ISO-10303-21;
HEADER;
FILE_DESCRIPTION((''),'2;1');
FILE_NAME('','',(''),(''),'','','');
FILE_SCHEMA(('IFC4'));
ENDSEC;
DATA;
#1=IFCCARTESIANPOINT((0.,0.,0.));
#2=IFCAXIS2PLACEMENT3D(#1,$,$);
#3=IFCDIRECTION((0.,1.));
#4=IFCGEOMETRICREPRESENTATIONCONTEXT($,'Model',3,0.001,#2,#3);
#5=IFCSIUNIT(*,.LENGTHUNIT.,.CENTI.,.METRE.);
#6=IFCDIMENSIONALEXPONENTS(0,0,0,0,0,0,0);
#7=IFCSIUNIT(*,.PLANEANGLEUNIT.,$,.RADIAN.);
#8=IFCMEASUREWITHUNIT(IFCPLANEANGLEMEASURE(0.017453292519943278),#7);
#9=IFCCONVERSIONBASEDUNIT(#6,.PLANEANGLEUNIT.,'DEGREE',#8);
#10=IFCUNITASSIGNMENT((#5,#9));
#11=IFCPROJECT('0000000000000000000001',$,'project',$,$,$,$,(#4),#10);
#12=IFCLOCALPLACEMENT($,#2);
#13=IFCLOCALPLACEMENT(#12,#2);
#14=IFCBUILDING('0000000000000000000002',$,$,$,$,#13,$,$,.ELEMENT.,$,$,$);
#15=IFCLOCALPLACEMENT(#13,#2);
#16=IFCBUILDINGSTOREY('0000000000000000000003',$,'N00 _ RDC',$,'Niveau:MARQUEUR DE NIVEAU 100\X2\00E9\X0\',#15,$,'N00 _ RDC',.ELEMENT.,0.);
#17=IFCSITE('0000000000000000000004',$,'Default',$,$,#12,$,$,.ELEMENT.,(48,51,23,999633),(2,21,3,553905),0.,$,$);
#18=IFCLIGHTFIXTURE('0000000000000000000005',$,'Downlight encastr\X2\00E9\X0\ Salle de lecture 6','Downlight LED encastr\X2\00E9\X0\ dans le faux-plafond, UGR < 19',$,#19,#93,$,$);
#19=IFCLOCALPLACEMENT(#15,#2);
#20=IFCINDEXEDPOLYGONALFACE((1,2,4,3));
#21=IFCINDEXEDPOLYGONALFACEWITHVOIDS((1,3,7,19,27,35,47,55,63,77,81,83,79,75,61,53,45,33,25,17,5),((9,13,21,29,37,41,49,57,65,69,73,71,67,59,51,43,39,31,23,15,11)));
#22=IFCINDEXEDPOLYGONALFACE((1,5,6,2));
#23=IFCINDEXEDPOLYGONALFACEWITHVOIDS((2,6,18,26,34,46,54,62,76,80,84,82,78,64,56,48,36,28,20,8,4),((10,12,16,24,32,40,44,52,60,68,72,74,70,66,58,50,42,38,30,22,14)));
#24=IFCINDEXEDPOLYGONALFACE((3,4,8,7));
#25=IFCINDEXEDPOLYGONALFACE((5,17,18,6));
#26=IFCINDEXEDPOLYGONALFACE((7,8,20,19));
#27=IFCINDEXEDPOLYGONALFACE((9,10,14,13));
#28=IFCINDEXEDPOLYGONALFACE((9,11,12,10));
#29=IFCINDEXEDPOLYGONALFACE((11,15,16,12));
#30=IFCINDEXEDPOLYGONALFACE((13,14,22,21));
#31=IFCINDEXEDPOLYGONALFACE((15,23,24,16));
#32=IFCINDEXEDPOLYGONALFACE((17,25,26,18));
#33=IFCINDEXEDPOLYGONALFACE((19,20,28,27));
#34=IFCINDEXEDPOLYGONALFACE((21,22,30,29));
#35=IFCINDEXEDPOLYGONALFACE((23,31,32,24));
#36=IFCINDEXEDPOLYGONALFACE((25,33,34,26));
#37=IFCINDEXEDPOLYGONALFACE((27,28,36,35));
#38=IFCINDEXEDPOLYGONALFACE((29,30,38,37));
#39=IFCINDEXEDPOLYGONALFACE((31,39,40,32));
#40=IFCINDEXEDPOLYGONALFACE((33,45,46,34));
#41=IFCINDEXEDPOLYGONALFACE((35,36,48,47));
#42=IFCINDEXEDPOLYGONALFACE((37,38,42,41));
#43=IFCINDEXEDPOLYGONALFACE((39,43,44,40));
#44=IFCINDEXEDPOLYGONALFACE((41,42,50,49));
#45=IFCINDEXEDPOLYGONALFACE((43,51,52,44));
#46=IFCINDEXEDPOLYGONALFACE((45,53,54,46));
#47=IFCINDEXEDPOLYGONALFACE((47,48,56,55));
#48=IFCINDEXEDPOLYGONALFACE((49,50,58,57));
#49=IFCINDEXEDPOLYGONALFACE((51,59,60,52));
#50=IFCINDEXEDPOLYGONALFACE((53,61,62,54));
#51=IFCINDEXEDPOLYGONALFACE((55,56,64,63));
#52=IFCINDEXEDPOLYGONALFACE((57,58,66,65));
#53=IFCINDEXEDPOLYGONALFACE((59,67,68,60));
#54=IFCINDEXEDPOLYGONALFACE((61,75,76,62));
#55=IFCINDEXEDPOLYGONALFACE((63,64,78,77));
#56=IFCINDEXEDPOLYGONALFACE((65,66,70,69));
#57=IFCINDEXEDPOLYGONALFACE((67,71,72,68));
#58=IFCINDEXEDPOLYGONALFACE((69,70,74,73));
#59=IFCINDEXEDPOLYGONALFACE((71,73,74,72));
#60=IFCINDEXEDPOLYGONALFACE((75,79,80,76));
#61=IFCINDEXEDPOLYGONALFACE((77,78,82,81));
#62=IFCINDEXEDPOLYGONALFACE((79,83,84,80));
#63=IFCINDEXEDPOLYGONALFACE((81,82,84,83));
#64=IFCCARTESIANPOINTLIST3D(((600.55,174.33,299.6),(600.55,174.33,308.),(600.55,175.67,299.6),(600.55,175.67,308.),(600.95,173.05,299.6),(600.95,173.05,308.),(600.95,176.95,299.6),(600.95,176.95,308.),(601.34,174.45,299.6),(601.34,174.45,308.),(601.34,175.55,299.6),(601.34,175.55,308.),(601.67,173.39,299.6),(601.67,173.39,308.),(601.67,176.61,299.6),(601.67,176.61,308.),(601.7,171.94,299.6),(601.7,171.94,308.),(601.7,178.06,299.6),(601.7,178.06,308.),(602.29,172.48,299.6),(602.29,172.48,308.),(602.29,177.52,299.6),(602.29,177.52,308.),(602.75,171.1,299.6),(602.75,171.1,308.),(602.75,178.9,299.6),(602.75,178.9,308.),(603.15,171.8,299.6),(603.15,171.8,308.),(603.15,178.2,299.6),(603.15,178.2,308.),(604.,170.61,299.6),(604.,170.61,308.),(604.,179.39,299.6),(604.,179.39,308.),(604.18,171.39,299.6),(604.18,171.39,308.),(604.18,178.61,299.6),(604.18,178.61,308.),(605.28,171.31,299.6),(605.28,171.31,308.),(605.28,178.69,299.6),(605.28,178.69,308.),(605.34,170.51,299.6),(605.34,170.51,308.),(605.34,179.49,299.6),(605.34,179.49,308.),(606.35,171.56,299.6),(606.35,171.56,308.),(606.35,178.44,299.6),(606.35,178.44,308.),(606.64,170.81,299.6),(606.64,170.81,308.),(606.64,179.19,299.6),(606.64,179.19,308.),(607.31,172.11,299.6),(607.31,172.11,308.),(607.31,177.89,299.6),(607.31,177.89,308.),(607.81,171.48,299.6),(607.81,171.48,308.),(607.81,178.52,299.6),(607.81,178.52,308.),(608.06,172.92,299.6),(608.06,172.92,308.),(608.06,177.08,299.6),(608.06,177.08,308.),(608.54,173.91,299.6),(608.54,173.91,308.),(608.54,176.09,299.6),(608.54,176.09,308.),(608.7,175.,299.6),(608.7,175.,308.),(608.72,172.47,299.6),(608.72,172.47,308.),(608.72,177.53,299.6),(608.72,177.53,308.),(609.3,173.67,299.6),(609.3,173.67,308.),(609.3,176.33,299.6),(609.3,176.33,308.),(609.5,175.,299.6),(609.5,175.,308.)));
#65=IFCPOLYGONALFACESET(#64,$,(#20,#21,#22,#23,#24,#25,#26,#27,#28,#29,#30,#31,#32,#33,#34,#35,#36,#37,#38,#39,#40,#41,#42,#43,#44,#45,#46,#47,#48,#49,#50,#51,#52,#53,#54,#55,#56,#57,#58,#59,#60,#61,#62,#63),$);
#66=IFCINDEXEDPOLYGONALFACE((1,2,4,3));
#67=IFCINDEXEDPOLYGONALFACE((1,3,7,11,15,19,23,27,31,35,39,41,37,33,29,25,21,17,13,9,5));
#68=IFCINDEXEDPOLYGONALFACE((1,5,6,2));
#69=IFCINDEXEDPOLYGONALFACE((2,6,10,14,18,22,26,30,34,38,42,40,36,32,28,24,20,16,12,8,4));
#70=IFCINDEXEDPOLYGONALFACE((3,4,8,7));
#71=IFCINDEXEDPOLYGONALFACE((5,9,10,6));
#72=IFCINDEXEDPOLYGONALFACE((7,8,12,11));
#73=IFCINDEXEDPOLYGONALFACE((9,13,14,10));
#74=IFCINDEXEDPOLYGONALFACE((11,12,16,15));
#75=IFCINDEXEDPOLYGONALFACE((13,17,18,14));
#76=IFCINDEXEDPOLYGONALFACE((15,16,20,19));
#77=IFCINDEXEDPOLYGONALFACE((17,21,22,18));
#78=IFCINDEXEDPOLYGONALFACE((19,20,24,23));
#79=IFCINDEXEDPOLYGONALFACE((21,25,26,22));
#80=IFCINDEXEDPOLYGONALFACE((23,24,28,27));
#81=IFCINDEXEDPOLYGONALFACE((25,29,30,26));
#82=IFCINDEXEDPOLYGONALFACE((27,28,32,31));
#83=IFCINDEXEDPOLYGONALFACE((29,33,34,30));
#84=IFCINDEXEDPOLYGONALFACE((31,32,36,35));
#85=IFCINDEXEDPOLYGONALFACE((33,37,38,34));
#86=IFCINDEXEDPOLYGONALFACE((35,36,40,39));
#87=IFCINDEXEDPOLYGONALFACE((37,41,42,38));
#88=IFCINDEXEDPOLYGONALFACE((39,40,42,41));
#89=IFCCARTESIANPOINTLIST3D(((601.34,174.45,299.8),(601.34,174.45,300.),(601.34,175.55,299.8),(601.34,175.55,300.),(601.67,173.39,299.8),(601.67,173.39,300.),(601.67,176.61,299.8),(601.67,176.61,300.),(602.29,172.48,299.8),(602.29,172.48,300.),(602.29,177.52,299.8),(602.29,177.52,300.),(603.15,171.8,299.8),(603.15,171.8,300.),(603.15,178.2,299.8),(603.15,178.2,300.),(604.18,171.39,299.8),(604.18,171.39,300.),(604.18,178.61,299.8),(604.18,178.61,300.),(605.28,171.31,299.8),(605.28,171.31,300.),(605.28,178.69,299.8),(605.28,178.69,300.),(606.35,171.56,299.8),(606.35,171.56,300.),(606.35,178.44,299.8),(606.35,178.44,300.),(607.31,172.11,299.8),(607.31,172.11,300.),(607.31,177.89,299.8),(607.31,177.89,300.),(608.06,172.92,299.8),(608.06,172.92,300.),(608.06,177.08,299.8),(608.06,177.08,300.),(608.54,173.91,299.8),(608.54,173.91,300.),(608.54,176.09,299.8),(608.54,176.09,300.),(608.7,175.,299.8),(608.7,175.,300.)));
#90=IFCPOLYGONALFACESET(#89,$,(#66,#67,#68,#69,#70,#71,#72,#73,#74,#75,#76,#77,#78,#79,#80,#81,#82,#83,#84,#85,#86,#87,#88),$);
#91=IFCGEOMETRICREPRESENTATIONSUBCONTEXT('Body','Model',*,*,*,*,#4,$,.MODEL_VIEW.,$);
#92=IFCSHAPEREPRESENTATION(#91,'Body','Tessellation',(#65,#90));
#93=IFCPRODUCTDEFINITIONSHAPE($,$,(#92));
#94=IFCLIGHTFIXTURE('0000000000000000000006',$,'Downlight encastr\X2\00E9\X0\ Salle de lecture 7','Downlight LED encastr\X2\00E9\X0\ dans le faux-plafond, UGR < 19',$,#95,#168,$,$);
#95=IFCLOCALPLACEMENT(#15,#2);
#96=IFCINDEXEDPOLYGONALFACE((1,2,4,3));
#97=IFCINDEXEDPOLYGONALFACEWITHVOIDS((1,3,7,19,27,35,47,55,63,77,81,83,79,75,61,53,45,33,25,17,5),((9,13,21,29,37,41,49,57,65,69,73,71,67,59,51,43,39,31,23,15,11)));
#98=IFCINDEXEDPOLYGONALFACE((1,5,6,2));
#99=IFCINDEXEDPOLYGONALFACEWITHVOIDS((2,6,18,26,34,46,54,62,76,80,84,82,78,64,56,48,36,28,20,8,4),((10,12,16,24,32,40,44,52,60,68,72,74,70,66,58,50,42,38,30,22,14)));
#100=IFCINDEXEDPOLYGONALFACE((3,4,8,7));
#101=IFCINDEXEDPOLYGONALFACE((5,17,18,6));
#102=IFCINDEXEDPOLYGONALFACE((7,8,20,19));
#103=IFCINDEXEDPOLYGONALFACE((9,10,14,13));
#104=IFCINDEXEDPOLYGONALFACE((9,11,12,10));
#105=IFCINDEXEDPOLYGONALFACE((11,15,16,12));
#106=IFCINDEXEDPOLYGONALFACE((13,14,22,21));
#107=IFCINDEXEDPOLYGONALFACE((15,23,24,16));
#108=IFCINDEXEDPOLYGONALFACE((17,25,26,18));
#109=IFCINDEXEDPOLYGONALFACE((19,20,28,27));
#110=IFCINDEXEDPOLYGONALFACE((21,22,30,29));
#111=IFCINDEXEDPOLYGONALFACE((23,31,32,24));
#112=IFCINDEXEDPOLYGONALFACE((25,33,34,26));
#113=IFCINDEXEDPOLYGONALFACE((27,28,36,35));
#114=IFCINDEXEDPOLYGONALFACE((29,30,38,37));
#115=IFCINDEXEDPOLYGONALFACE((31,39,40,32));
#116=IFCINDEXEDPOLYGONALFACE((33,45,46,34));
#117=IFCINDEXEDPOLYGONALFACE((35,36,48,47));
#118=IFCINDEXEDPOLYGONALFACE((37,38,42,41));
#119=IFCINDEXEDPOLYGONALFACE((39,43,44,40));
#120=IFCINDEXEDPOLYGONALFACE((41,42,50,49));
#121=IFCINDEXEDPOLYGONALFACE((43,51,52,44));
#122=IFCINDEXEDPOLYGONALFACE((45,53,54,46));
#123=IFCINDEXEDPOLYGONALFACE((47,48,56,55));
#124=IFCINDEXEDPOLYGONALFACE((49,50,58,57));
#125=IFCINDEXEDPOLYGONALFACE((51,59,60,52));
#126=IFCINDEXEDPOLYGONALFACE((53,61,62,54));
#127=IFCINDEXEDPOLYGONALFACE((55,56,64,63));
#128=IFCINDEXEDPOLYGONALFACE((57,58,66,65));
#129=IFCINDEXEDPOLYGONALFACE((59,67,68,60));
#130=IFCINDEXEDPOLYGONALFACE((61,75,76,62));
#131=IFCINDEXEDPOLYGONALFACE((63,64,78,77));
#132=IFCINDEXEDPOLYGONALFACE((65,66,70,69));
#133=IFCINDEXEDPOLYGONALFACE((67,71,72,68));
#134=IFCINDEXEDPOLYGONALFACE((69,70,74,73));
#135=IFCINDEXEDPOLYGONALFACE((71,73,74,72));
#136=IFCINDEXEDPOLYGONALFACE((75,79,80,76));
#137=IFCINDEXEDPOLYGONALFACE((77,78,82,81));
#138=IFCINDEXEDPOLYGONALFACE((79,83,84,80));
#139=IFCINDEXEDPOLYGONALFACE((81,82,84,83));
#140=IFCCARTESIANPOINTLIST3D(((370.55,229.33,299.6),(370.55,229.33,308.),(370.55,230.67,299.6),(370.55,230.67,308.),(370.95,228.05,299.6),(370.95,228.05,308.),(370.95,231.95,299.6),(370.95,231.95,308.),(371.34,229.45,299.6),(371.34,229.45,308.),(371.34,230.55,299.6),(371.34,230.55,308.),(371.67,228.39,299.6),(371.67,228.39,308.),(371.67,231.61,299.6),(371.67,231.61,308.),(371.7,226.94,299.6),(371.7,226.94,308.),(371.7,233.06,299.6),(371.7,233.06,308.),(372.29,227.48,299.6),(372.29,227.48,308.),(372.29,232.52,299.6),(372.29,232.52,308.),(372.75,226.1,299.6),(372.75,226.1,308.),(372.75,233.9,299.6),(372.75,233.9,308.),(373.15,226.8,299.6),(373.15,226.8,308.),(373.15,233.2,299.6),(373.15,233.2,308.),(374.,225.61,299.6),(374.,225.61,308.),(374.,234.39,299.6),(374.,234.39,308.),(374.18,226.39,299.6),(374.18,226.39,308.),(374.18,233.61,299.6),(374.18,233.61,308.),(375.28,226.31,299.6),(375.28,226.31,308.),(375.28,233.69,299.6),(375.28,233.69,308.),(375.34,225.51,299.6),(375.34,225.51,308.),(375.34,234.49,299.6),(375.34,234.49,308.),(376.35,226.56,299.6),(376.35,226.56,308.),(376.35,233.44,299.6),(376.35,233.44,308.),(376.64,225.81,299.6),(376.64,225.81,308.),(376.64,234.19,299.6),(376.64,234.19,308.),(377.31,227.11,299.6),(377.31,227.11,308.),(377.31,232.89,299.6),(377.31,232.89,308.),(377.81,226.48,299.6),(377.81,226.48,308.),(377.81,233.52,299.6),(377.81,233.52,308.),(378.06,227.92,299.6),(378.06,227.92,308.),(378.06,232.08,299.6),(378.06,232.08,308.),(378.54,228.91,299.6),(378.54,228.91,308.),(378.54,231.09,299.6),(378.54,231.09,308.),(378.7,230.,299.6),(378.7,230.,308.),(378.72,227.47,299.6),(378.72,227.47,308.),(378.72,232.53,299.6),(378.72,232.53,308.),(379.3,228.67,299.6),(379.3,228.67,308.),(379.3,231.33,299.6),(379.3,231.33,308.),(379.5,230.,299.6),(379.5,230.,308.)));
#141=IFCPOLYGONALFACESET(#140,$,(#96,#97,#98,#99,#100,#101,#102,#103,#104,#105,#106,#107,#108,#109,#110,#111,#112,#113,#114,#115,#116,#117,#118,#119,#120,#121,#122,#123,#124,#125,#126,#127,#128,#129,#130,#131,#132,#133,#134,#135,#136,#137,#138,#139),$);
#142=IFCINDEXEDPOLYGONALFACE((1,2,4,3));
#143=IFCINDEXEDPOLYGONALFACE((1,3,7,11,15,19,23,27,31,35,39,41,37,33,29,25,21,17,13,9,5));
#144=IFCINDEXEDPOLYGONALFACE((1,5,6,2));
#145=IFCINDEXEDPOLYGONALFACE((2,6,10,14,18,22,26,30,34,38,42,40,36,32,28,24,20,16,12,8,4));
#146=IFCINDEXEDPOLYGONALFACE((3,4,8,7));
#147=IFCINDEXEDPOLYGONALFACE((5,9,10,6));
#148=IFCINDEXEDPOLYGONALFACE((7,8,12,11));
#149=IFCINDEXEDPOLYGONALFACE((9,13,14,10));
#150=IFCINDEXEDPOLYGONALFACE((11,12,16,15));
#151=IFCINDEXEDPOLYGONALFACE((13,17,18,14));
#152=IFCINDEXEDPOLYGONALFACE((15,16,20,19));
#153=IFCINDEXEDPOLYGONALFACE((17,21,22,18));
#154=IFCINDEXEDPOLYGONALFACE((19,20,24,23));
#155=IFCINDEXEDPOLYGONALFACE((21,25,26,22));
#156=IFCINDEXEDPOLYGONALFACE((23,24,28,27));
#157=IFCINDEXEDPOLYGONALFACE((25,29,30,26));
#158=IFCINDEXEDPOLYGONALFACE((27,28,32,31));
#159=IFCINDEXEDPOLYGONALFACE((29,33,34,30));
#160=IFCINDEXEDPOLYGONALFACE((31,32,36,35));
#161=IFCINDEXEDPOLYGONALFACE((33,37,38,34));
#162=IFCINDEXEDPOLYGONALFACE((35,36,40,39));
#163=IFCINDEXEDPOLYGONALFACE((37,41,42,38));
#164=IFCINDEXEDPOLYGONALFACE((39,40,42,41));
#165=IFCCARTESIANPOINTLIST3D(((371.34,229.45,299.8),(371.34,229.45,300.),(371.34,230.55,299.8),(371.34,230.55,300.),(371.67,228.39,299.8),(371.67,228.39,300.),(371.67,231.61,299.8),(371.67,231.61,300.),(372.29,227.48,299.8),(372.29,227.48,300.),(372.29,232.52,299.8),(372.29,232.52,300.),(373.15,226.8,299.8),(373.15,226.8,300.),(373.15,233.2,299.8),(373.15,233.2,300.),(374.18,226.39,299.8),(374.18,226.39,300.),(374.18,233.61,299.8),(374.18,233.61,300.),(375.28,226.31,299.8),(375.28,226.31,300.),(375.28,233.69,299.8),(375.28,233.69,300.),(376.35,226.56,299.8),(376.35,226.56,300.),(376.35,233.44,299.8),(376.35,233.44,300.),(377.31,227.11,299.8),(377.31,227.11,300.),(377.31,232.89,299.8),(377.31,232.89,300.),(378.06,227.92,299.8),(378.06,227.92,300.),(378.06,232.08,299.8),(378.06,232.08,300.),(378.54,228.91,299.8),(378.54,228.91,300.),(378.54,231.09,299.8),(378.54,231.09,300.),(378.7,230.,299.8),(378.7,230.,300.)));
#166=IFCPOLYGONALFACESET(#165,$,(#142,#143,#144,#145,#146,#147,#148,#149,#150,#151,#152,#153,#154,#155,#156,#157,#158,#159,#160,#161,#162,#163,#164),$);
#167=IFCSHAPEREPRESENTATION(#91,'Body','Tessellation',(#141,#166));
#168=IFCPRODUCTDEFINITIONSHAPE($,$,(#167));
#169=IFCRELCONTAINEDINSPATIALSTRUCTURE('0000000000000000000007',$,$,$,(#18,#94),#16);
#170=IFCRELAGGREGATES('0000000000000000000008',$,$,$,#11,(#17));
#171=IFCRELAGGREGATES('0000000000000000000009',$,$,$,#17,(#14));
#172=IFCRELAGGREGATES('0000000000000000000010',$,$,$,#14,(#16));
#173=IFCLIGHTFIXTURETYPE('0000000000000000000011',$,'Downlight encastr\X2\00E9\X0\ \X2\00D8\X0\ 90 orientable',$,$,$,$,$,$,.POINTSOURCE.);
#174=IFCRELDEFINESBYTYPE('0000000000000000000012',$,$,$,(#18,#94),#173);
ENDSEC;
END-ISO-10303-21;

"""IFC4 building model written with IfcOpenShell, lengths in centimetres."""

from ifc_helpers import new_model, entity, si_unit, converted_unit, direction, frame, frame_2d, origin, origin_with_axes, place, context, subcontext, project, spatial, circle, hollow_circle, extrude, type_object, element, save


model = new_model("IFC4")

# Units and contexts
model_context = context("Model", 3, precision=0.001, world=origin(), true_north=direction((0.0, 1.0)))
body_context = subcontext(model_context, "Body", "Model", "MODEL_VIEW")
ifc_project = project(units=[si_unit("LENGTHUNIT", "METRE", prefix="CENTI"), converted_unit("PLANEANGLEUNIT", "DEGREE", entity("IfcPlaneAngleMeasure", 0.017453292519943278), si_unit("PLANEANGLEUNIT", "RADIAN"), dimensions=[0, 0, 0, 0, 0, 0, 0])], contexts=[model_context])

# Site, building, storey
site_placement = place(None, origin())
site = spatial("IfcSite", under=ifc_project, at=site_placement, Name="Default", CompositionType="ELEMENT", RefLatitude=(48, 51, 23, 999633), RefLongitude=(2, 21, 3, 553905), RefElevation=0.0)
building_placement = place(site_placement, origin())
building = spatial("IfcBuilding", under=site, at=building_placement, CompositionType="ELEMENT")
storey_placement = place(building_placement, origin())
storey = spatial("IfcBuildingStorey", under=building, at=storey_placement, Name="N00 _ RDC", ObjectType="Niveau:MARQUEUR DE NIVEAU 100é", LongName="N00 _ RDC", CompositionType="ELEMENT", Elevation=0.0)

# Light fixtures
light_fixture_type_1 = type_object("IfcLightFixtureType", Name="Downlight encastré Ø 90 orientable", PredefinedType="POINTSOURCE")
light_fixture_1_placement = place(storey_placement, origin_with_axes())
element("IfcLightFixture", 1, at=light_fixture_1_placement, inside=storey, type_object=light_fixture_type_1, Name="Downlight encastré Salle de lecture 6", Description="Downlight LED encastré dans le faux-plafond, UGR < 19", context=body_context, shape_type="SweptSolid", body=[
    extrude(hollow_circle(Radius=4.5, WallThickness=0.8, at=frame_2d((605.0, 175.0))), frame((0.0, 0.0, 299.6)), (0.0, 0.0, 1.0), 8.4),
    extrude(circle(Radius=3.7, at=frame_2d((605.0, 175.0))), frame((0.0, 0.0, 299.8)), (0.0, 0.0, 1.0), 0.2),
])
light_fixture_2_placement = place(storey_placement, origin_with_axes())
element("IfcLightFixture", 2, at=light_fixture_2_placement, inside=storey, type_object=light_fixture_type_1, Name="Downlight encastré Salle de lecture 7", Description="Downlight LED encastré dans le faux-plafond, UGR < 19", context=body_context, shape_type="SweptSolid", body=[
    extrude(hollow_circle(Radius=4.5, WallThickness=0.8, at=frame_2d((375.0, 230.0))), frame((0.0, 0.0, 299.6)), (0.0, 0.0, 1.0), 8.4),
    extrude(circle(Radius=3.7, at=frame_2d((375.0, 230.0))), frame((0.0, 0.0, 299.8)), (0.0, 0.0, 1.0), 0.2),
])

save(model, "model.ifc")
